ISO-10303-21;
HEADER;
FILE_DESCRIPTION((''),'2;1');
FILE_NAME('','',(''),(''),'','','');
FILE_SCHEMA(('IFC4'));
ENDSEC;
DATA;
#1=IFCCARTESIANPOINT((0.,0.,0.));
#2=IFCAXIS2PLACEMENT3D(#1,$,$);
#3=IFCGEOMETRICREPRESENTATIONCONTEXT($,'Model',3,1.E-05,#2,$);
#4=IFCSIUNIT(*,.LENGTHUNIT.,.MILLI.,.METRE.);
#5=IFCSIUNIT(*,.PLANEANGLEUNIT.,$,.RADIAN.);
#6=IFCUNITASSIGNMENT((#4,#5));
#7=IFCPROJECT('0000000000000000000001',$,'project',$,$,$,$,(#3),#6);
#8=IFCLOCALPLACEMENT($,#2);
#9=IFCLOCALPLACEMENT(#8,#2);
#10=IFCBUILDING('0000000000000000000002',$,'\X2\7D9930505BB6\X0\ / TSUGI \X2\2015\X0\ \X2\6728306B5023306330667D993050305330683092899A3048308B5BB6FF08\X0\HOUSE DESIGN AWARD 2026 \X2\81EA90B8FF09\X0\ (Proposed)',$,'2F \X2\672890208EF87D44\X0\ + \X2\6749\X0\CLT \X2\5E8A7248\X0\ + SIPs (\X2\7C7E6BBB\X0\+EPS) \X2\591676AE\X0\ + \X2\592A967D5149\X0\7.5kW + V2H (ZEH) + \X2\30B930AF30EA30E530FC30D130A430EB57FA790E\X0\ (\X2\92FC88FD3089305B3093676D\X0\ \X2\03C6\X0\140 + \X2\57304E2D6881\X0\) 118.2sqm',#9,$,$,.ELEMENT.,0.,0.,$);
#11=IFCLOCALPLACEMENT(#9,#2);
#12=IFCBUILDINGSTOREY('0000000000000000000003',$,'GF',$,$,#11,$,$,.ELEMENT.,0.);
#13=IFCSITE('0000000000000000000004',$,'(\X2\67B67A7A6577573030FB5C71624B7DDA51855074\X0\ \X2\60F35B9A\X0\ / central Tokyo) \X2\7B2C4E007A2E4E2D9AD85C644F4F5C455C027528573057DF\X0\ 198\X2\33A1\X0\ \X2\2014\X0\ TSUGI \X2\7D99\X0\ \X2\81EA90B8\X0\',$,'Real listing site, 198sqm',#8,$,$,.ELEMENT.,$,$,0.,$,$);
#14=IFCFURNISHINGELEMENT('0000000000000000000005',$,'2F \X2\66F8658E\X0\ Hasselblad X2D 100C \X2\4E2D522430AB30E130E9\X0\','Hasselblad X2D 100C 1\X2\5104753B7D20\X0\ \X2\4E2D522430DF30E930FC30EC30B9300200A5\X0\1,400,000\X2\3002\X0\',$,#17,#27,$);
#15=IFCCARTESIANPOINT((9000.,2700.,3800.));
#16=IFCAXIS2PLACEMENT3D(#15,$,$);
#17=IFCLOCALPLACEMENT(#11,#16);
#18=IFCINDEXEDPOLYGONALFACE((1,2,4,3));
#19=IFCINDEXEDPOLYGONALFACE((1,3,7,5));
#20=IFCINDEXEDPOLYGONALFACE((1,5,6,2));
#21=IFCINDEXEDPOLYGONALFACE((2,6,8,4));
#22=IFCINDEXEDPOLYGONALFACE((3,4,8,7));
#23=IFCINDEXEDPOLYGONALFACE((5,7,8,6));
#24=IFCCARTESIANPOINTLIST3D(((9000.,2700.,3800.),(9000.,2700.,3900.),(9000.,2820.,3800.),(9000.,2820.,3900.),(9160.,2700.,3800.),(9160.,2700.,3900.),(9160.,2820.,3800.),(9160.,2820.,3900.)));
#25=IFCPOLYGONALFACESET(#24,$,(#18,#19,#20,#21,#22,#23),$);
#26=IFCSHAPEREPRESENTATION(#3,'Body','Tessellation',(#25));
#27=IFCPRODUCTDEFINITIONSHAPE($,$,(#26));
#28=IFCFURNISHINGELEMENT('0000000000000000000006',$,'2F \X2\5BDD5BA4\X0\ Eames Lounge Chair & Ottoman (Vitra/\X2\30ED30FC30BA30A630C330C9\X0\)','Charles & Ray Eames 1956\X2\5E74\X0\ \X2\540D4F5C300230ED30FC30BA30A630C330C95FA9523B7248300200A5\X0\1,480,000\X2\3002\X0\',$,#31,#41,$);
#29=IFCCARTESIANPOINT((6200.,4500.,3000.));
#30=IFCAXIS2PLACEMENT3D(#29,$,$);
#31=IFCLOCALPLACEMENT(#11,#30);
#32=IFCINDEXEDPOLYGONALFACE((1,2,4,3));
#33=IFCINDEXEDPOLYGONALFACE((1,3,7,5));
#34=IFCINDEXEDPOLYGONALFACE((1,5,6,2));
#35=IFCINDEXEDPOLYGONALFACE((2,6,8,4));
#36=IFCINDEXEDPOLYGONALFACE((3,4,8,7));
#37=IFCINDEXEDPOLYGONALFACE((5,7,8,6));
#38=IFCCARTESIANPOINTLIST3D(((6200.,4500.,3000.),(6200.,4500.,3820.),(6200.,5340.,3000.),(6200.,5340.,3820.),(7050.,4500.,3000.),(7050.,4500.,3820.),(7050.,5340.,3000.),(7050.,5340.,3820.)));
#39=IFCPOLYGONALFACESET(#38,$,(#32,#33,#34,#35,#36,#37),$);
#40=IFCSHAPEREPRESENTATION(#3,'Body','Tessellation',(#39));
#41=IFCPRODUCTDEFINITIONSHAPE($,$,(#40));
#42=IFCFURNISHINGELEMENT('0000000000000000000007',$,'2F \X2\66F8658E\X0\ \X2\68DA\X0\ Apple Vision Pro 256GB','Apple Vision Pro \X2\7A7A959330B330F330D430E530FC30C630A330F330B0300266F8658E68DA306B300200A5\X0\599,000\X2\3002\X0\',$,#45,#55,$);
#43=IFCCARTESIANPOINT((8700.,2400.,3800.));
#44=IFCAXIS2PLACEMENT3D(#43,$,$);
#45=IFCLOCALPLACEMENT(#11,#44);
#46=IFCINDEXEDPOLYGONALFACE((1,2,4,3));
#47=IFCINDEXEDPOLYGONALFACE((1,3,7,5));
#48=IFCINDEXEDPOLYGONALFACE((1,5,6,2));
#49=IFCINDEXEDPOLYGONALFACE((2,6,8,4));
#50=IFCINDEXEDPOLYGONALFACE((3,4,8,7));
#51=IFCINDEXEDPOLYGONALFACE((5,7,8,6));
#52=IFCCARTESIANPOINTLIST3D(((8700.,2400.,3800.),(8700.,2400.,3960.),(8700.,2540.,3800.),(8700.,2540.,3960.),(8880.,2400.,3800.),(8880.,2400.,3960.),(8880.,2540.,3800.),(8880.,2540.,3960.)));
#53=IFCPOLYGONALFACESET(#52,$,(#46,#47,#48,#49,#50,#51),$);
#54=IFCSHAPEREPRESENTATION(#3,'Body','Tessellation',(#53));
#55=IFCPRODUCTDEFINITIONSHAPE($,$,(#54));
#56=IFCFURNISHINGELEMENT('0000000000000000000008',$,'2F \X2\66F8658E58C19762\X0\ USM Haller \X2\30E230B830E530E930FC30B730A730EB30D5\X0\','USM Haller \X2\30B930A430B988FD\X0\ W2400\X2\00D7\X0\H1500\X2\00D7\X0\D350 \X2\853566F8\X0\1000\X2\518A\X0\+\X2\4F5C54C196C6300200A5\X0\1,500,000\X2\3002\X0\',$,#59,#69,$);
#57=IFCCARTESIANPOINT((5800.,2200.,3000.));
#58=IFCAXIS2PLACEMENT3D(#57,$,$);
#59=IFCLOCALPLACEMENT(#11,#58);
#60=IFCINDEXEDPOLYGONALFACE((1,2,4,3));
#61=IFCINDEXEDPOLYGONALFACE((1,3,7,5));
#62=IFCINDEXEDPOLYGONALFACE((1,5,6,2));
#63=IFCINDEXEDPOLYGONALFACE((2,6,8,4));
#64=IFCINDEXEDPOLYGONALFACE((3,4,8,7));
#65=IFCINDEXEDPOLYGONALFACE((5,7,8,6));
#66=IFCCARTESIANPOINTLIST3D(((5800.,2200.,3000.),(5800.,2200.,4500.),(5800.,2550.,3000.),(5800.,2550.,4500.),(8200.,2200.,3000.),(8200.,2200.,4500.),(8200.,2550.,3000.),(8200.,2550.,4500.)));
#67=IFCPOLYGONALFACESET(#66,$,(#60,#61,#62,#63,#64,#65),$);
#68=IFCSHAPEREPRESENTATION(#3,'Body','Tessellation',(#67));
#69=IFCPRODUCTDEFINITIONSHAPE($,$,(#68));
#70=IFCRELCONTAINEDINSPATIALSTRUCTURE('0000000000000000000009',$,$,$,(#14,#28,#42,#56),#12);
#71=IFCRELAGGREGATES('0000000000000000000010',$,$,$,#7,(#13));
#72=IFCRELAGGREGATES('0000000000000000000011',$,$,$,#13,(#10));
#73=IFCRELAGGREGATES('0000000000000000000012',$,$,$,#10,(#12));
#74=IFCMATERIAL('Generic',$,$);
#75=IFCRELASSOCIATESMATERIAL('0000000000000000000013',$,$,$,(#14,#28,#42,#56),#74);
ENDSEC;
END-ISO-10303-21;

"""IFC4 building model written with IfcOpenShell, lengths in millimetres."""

from ifc_helpers import new_model, si_unit, frame, frame_2d, origin, place, context, project, spatial, rectangle, extrude, material, element, save


model = new_model("IFC4")

# Units and contexts
model_context = context("Model", 3, precision=1e-05, world=origin())
ifc_project = project(units=[si_unit("LENGTHUNIT", "METRE", prefix="MILLI"), si_unit("PLANEANGLEUNIT", "RADIAN")], contexts=[model_context])

# Site, building, storey
site_placement = place(None, origin())
site = spatial("IfcSite", under=ifc_project, at=site_placement, Name="(架空敷地・山手線内側 想定 / central Tokyo) 第一種中高層住居専用地域 198㎡ — TSUGI 継 自邸", ObjectType="Real listing site, 198sqm", CompositionType="ELEMENT", RefElevation=0.0)
building_placement = place(site_placement, origin())
building = spatial("IfcBuilding", under=site, at=building_placement, Name="継ぐ家 / TSUGI ― 木に倣って継ぐことを覚える家（HOUSE DESIGN AWARD 2026 自邸） (Proposed)", ObjectType="2F 木造軸組 + 杉CLT 床版 + SIPs (籾殻+EPS) 外皮 + 太陽光7.5kW + V2H (ZEH) + スクリューパイル基礎 (鋼製らせん杭 φ140 + 地中梁) 118.2sqm", CompositionType="ELEMENT", ElevationOfRefHeight=0.0, ElevationOfTerrain=0.0)
storey_placement = place(building_placement, origin())
storey = spatial("IfcBuildingStorey", under=building, at=storey_placement, Name="GF", CompositionType="ELEMENT", Elevation=0.0)

# Shared definitions
ifc_material_1 = material(Name="Generic")

# Furnishing elements
furnishing_1_placement = place(storey_placement, frame((9000.0, 2700.0, 3800.0)))
element("IfcFurnishingElement", 1, at=furnishing_1_placement, inside=storey, material=ifc_material_1, Name="2F 書斎 Hasselblad X2D 100C 中判カメラ", Description="Hasselblad X2D 100C 1億画素 中判ミラーレス。¥1,400,000。", context=model_context, shape_type="SweptSolid", body=[
    extrude(rectangle(XDim=160.0, YDim=120.0, at=frame_2d((80.0, 60.0))), frame((9000.0, 2700.0, 3800.0)), (0.0, 0.0, 1.0), 100.0),
])
furnishing_2_placement = place(storey_placement, frame((6200.0, 4500.0, 3000.0)))
element("IfcFurnishingElement", 2, at=furnishing_2_placement, inside=storey, material=ifc_material_1, Name="2F 寝室 Eames Lounge Chair & Ottoman (Vitra/ローズウッド)", Description="Charles & Ray Eames 1956年 名作。ローズウッド復刻版。¥1,480,000。", context=model_context, shape_type="SweptSolid", body=[
    extrude(rectangle(XDim=850.0, YDim=840.0, at=frame_2d((425.0, 420.0))), frame((6200.0, 4500.0, 3000.0)), (0.0, 0.0, 1.0), 820.0),
])
furnishing_3_placement = place(storey_placement, frame((8700.0, 2400.0, 3800.0)))
element("IfcFurnishingElement", 3, at=furnishing_3_placement, inside=storey, material=ifc_material_1, Name="2F 書斎 棚 Apple Vision Pro 256GB", Description="Apple Vision Pro 空間コンピューティング。書斎棚に。¥599,000。", context=model_context, shape_type="SweptSolid", body=[
    extrude(rectangle(XDim=180.0, YDim=140.0, at=frame_2d((90.0, 70.0))), frame((8700.0, 2400.0, 3800.0)), (0.0, 0.0, 1.0), 160.0),
])
furnishing_4_placement = place(storey_placement, frame((5800.0, 2200.0, 3000.0)))
element("IfcFurnishingElement", 4, at=furnishing_4_placement, inside=storey, material=ifc_material_1, Name="2F 書斎壁面 USM Haller モジュラーシェルフ", Description="USM Haller スイス製 W2400×H1500×D350 蔵書1000冊+作品集。¥1,500,000。", context=model_context, shape_type="SweptSolid", body=[
    extrude(rectangle(XDim=2400.0, YDim=350.0, at=frame_2d((1200.0, 175.0))), frame((5800.0, 2200.0, 3000.0)), (0.0, 0.0, 1.0), 1500.0),
])

save(model, "model.ifc")
